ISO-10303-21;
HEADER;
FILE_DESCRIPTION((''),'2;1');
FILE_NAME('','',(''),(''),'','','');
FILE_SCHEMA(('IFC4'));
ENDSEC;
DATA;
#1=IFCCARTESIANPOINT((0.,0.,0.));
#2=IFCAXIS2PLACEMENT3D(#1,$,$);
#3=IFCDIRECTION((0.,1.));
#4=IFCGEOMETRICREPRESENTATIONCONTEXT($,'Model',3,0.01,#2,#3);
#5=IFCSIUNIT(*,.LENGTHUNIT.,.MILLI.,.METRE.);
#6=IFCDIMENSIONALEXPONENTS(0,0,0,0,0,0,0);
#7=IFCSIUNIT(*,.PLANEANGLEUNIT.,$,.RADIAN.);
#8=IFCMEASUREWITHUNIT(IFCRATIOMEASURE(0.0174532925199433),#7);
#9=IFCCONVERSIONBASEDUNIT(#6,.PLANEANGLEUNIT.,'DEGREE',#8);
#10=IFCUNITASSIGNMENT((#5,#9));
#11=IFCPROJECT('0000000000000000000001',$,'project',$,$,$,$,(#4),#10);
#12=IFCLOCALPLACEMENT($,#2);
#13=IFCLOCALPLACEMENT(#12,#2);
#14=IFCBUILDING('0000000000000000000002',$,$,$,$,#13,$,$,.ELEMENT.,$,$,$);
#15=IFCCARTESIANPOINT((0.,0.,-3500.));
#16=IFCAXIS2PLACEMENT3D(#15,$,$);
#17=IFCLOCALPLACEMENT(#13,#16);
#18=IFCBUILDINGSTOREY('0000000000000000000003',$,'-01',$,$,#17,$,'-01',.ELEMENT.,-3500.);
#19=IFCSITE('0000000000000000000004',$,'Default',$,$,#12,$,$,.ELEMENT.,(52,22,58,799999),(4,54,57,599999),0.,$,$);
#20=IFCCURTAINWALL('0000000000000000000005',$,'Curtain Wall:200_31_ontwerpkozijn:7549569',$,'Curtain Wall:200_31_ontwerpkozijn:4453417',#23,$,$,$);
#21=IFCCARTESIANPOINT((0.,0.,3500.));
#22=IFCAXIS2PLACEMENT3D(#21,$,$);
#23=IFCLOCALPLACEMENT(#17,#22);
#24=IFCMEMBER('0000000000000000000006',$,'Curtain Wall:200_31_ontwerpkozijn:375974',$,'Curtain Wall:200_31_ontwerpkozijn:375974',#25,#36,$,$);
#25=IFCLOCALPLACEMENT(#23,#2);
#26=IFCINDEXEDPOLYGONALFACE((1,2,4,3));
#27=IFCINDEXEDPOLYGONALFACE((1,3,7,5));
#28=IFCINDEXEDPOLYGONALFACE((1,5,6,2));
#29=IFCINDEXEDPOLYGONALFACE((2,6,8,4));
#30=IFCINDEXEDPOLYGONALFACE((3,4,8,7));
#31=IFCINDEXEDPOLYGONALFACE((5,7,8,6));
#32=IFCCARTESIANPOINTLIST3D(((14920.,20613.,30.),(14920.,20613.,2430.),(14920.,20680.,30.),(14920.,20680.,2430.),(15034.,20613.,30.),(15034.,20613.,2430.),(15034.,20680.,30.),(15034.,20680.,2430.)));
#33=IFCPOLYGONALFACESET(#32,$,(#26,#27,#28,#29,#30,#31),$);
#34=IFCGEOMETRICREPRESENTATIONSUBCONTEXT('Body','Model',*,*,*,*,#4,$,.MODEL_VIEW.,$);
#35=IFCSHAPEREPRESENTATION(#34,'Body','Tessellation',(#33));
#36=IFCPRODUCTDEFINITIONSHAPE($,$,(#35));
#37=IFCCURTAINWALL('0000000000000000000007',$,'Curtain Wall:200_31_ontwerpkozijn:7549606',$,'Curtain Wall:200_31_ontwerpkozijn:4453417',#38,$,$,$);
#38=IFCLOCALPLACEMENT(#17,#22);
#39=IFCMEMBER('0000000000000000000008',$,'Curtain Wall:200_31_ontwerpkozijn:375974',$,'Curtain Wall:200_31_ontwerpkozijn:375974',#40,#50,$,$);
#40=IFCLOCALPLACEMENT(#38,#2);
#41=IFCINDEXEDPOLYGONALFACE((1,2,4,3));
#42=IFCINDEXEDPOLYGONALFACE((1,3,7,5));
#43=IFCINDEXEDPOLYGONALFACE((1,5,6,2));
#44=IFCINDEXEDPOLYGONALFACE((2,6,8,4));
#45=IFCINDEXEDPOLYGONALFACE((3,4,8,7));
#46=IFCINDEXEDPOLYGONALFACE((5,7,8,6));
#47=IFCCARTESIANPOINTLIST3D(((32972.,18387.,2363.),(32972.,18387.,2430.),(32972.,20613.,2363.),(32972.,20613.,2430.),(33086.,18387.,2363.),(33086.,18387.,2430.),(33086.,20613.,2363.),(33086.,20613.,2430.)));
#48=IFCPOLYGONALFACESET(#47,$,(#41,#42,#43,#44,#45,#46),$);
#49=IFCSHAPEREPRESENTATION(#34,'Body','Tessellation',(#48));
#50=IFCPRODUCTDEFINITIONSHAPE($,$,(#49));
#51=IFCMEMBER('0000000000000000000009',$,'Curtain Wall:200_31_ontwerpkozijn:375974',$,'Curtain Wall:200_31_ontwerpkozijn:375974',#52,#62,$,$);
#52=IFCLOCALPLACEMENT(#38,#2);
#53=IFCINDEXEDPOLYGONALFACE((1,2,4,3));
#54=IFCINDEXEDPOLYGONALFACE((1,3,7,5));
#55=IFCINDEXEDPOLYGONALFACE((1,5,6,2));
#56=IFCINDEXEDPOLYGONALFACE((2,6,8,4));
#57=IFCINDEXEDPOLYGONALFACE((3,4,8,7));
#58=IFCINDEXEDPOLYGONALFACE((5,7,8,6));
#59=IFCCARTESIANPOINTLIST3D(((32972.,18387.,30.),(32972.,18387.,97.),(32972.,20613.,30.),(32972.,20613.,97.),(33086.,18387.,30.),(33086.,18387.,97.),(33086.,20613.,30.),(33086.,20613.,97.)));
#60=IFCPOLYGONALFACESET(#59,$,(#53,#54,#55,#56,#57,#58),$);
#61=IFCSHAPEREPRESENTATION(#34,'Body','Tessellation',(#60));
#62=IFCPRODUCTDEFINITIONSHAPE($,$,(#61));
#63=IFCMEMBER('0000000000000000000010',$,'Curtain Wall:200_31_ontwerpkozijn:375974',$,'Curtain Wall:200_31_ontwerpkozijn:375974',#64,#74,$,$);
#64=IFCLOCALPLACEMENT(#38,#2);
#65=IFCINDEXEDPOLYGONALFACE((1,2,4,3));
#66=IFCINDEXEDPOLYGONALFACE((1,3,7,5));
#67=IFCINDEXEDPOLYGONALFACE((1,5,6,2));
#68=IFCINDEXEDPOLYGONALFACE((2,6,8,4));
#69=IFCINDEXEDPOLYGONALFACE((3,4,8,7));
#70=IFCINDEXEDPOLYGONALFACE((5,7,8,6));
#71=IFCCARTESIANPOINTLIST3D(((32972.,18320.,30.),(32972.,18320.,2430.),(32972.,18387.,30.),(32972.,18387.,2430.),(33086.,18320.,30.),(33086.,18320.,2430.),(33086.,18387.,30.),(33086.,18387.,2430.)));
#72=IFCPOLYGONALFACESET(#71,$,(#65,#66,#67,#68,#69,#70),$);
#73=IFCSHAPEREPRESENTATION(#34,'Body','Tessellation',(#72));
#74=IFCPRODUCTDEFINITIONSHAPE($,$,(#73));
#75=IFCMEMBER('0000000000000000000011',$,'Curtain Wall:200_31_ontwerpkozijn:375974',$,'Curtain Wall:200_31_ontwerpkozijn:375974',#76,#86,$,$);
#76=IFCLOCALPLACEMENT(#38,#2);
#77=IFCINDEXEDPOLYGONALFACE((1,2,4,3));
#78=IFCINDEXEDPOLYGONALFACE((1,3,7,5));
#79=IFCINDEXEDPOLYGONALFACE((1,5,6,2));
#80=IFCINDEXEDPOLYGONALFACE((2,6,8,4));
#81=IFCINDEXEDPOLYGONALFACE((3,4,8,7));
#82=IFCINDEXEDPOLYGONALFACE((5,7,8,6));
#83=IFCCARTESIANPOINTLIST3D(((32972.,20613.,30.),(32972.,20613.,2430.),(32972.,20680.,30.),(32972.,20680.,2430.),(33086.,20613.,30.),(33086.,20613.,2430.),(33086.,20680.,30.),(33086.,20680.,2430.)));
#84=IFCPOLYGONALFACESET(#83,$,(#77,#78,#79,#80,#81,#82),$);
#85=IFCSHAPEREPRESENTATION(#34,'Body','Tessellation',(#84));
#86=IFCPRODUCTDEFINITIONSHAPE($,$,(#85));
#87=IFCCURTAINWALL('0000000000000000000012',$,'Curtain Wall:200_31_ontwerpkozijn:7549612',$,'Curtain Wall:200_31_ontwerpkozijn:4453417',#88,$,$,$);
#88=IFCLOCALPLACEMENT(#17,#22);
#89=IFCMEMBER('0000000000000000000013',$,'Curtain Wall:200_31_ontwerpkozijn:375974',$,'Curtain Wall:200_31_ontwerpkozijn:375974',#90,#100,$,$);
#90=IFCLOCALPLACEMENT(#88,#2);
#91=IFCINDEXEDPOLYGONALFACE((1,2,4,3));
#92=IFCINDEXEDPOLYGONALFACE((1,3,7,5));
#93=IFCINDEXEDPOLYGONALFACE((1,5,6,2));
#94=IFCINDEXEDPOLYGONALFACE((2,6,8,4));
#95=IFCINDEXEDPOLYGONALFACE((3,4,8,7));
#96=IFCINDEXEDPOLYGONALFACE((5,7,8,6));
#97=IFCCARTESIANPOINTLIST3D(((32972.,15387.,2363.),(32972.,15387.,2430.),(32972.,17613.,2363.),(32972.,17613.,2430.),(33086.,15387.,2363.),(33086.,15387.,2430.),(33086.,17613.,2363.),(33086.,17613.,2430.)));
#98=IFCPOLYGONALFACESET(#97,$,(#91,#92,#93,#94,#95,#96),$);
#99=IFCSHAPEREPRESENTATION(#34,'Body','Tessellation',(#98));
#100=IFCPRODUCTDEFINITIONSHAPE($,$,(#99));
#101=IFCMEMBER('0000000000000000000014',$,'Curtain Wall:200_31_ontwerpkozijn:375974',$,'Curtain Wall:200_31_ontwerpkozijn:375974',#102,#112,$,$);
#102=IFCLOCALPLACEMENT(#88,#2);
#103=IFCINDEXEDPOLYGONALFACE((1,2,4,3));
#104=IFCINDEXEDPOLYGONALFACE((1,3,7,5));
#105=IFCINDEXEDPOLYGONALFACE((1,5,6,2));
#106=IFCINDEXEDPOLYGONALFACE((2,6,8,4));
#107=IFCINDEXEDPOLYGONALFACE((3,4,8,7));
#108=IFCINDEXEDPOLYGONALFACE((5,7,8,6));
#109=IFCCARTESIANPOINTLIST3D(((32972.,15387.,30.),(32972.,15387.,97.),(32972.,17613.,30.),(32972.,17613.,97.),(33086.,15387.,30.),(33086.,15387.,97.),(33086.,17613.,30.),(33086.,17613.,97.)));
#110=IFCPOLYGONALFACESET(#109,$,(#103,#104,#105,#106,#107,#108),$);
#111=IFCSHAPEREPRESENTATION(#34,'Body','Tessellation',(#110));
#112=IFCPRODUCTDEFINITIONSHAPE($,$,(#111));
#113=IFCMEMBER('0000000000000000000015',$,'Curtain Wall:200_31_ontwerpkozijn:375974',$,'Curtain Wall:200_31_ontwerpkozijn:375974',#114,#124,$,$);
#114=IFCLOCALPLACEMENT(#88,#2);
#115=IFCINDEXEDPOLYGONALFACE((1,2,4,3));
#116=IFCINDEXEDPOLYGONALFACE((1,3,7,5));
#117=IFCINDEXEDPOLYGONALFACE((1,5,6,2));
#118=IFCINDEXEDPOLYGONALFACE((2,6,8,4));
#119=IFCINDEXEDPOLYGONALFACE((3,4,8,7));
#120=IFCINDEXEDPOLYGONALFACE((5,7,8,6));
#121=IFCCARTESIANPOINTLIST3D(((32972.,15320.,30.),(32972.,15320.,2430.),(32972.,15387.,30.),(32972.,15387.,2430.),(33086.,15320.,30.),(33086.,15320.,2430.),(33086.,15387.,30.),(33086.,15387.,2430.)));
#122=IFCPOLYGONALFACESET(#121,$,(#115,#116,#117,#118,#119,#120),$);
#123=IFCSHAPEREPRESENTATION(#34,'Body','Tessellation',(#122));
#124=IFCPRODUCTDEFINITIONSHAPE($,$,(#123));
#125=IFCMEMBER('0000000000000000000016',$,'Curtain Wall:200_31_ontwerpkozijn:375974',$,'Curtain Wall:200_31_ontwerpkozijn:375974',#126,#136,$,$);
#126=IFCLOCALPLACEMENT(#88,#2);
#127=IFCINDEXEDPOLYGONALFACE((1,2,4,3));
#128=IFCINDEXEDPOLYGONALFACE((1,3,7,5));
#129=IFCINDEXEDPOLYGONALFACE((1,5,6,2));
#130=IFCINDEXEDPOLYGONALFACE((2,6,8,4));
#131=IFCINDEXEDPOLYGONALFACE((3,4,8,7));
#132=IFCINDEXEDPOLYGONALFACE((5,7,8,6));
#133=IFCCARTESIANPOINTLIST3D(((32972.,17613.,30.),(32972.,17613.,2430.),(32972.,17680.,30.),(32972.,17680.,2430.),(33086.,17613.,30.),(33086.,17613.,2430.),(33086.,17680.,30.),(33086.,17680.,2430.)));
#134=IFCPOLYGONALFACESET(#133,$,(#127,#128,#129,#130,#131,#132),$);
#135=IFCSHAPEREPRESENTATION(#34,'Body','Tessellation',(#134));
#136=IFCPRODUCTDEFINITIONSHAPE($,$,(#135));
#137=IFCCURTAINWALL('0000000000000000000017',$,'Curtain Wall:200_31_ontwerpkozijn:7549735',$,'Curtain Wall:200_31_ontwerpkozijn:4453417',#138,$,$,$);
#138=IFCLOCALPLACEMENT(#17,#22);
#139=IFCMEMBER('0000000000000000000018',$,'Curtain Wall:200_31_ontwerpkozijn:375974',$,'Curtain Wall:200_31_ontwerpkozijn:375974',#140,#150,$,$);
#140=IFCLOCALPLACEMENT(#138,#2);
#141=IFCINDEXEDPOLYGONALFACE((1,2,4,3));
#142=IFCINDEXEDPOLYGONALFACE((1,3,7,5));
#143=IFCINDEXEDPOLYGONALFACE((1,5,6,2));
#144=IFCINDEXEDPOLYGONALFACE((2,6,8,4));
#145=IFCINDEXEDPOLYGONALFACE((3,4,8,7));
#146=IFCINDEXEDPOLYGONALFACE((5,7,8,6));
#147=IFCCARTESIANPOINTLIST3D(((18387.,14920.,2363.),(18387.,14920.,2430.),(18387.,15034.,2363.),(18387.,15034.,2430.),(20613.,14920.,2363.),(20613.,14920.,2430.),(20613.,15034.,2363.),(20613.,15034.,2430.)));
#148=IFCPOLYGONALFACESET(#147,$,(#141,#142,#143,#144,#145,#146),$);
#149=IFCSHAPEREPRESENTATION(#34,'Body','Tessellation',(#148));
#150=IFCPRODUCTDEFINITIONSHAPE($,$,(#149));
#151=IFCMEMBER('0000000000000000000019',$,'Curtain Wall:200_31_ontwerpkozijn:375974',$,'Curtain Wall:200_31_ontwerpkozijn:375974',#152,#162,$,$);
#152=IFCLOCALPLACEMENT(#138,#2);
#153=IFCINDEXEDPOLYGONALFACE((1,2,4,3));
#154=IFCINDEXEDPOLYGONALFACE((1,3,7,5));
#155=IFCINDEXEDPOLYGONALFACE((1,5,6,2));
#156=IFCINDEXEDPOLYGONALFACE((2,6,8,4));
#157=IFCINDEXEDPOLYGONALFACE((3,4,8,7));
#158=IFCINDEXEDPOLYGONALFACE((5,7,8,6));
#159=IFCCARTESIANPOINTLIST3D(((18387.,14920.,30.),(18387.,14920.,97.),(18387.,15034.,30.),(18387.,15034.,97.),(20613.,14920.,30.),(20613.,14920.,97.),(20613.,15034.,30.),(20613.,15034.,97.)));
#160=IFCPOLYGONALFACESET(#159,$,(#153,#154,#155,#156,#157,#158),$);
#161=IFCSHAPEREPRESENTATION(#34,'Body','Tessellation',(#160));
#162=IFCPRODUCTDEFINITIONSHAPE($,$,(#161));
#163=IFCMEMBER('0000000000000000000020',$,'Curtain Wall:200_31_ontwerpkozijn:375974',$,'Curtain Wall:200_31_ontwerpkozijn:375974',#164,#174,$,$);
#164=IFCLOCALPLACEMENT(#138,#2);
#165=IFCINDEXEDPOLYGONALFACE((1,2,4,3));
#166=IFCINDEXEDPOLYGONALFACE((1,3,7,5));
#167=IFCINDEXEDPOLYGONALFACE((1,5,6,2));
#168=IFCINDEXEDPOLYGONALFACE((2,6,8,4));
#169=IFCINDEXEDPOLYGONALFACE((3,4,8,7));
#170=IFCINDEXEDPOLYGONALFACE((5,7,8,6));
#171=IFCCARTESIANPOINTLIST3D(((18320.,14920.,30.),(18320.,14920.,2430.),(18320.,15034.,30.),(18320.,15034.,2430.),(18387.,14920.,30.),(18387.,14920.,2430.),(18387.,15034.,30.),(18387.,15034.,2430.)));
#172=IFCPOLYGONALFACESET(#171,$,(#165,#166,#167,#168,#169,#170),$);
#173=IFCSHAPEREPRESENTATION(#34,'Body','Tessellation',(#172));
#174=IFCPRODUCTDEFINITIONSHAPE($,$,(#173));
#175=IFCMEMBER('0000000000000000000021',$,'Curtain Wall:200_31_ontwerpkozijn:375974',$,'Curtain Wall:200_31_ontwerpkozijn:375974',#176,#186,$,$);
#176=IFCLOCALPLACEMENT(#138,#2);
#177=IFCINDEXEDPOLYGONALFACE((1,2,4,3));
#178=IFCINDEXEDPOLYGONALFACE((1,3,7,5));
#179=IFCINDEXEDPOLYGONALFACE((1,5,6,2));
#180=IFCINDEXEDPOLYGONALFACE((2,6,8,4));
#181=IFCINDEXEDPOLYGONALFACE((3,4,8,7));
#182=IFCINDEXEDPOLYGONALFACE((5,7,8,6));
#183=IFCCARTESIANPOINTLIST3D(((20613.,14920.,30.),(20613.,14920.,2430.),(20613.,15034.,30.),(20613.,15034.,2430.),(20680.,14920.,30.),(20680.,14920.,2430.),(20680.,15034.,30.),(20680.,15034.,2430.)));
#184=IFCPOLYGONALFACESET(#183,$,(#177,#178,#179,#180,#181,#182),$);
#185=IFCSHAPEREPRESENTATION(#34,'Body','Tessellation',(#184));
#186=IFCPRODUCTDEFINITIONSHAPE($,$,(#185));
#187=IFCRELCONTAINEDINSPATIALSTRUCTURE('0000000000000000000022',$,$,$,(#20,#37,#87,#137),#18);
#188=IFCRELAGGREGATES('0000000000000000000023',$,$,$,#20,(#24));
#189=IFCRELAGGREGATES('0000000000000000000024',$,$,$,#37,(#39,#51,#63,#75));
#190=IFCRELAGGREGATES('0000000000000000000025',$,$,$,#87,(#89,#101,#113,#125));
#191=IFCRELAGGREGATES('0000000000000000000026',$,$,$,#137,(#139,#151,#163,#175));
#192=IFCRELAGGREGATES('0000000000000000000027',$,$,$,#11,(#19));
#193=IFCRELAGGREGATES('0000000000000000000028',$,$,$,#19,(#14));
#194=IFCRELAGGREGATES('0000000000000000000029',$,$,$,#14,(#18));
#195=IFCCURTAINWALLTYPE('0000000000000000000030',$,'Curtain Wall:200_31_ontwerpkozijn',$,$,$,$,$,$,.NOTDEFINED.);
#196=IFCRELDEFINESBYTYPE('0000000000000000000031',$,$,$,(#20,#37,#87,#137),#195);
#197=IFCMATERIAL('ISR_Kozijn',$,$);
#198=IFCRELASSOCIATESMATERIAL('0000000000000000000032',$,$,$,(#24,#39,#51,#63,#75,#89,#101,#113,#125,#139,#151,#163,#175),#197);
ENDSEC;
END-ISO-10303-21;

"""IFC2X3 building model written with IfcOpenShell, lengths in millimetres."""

from ifc_helpers import new_model, entity, si_unit, converted_unit, direction, frame, frame_2d, origin, origin_2d_with_axis, place, context, subcontext, project, spatial, rectangle, extrude, material, type_object, element, aggregate, save


model = new_model("IFC2X3")

# Units and contexts
model_context = context("Model", 3, precision=0.01, world=origin(), true_north=direction((0.0, 1.0)))
body_context = subcontext(model_context, "Body", "Model", "MODEL_VIEW")
ifc_project = project(units=[si_unit("LENGTHUNIT", "METRE", prefix="MILLI"), converted_unit("PLANEANGLEUNIT", "DEGREE", entity("IfcRatioMeasure", 0.0174532925199433), si_unit("PLANEANGLEUNIT", "RADIAN"), dimensions=[0, 0, 0, 0, 0, 0, 0])], contexts=[model_context])

# Site, building, storey
site_placement = place(None, origin())
site = spatial("IfcSite", under=ifc_project, at=site_placement, Name="Default", CompositionType="ELEMENT", RefLatitude=(52, 22, 58, 799999), RefLongitude=(4, 54, 57, 599999), RefElevation=0.0)
building_placement = place(site_placement, origin())
building = spatial("IfcBuilding", under=site, at=building_placement, CompositionType="ELEMENT")
storey_placement = place(building_placement, frame((0.0, 0.0, -3500.0)))
storey = spatial("IfcBuildingStorey", under=building, at=storey_placement, Name="-01", LongName="-01", CompositionType="ELEMENT", Elevation=-3500.0)

# Curtain wall, member
curtain_wall_type = type_object("IfcCurtainWallType", Name="Curtain Wall:200_31_ontwerpkozijn", PredefinedType="NOTDEFINED")
curtain_wall_1_placement = place(storey_placement, frame((0.0, 0.0, 3500.0)))
curtain_wall_1 = element("IfcCurtainWall", 1, at=curtain_wall_1_placement, inside=storey, type_object=curtain_wall_type, Name="Curtain Wall:200_31_ontwerpkozijn:7549569", ObjectType="Curtain Wall:200_31_ontwerpkozijn:4453417")
ifc_material = material(Name="ISR_Kozijn")
member_1_placement = place(curtain_wall_1_placement, origin())
member_1 = element("IfcMember", 2, at=member_1_placement, material=ifc_material, Name="Curtain Wall:200_31_ontwerpkozijn:375974", ObjectType="Curtain Wall:200_31_ontwerpkozijn:375974", context=body_context, shape_type="SweptSolid", body=[
    extrude(rectangle(XDim=114.0, YDim=67.0, at=origin_2d_with_axis()), frame((14977.0, 20646.5, 2430.0), z_axis=(0.0, 0.0, -1.0), x_axis=(-1.0, 0.0, 0.0)), (0.0, 0.0, 1.0), 2400.0),
])
aggregate(curtain_wall_1, [member_1])

# Curtain walls, members
curtain_wall_2_placement = place(storey_placement, frame((0.0, 0.0, 3500.0)))
curtain_wall_2 = element("IfcCurtainWall", 3, at=curtain_wall_2_placement, inside=storey, type_object=curtain_wall_type, Name="Curtain Wall:200_31_ontwerpkozijn:7549606", ObjectType="Curtain Wall:200_31_ontwerpkozijn:4453417")
member_2_placement = place(curtain_wall_2_placement, origin())
member_2 = element("IfcMember", 4, at=member_2_placement, material=ifc_material, Name="Curtain Wall:200_31_ontwerpkozijn:375974", ObjectType="Curtain Wall:200_31_ontwerpkozijn:375974", context=body_context, shape_type="SweptSolid", body=[
    extrude(rectangle(XDim=67.0, YDim=114.0, at=origin_2d_with_axis()), frame((33029.0, 18387.0, 2396.5), z_axis=(0.0, 1.0, 0.0), x_axis=(0.0, 0.0, -1.0)), (0.0, 0.0, 1.0), 2226.0),
])
member_3_placement = place(curtain_wall_2_placement, origin())
member_3 = element("IfcMember", 5, at=member_3_placement, material=ifc_material, Name="Curtain Wall:200_31_ontwerpkozijn:375974", ObjectType="Curtain Wall:200_31_ontwerpkozijn:375974", context=body_context, shape_type="SweptSolid", body=[
    extrude(rectangle(XDim=67.0, YDim=114.0, at=origin_2d_with_axis()), frame((33029.0, 20613.0, 63.5), z_axis=(0.0, -1.0, 0.0), x_axis=(0.0, 0.0, -1.0)), (0.0, 0.0, 1.0), 2226.0),
])
member_4_placement = place(curtain_wall_2_placement, origin())
member_4 = element("IfcMember", 6, at=member_4_placement, material=ifc_material, Name="Curtain Wall:200_31_ontwerpkozijn:375974", ObjectType="Curtain Wall:200_31_ontwerpkozijn:375974", context=body_context, shape_type="SweptSolid", body=[
    extrude(rectangle(XDim=114.0, YDim=67.0, at=frame_2d((0.0, 0.0), x_axis=(1.0, 0.0))), frame((33029.0, 18353.5, 30.0), z_axis=(0.0, 0.0, 1.0), x_axis=(-1.0, 0.0, 0.0)), (0.0, 0.0, 1.0), 2400.0),
])
member_5_placement = place(curtain_wall_2_placement, origin())
member_5 = element("IfcMember", 7, at=member_5_placement, material=ifc_material, Name="Curtain Wall:200_31_ontwerpkozijn:375974", ObjectType="Curtain Wall:200_31_ontwerpkozijn:375974", context=body_context, shape_type="SweptSolid", body=[
    extrude(rectangle(XDim=114.0, YDim=67.0, at=origin_2d_with_axis()), frame((33029.0, 20646.5, 2430.0), z_axis=(0.0, 0.0, -1.0), x_axis=(-1.0, 0.0, 0.0)), (0.0, 0.0, 1.0), 2400.0),
])
aggregate(curtain_wall_2, [member_2, member_3, member_4, member_5])
curtain_wall_3_placement = place(storey_placement, frame((0.0, 0.0, 3500.0)))
curtain_wall_3 = element("IfcCurtainWall", 8, at=curtain_wall_3_placement, inside=storey, type_object=curtain_wall_type, Name="Curtain Wall:200_31_ontwerpkozijn:7549612", ObjectType="Curtain Wall:200_31_ontwerpkozijn:4453417")
member_6_placement = place(curtain_wall_3_placement, origin())
member_6 = element("IfcMember", 9, at=member_6_placement, material=ifc_material, Name="Curtain Wall:200_31_ontwerpkozijn:375974", ObjectType="Curtain Wall:200_31_ontwerpkozijn:375974", context=body_context, shape_type="SweptSolid", body=[
    extrude(rectangle(XDim=67.0, YDim=114.0, at=origin_2d_with_axis()), frame((33029.0, 15387.0, 2396.5), z_axis=(0.0, 1.0, 0.0), x_axis=(0.0, 0.0, -1.0)), (0.0, 0.0, 1.0), 2226.0),
])
member_7_placement = place(curtain_wall_3_placement, origin())
member_7 = element("IfcMember", 10, at=member_7_placement, material=ifc_material, Name="Curtain Wall:200_31_ontwerpkozijn:375974", ObjectType="Curtain Wall:200_31_ontwerpkozijn:375974", context=body_context, shape_type="SweptSolid", body=[
    extrude(rectangle(XDim=67.0, YDim=114.0, at=origin_2d_with_axis()), frame((33029.0, 17613.0, 63.5), z_axis=(0.0, -1.0, 0.0), x_axis=(0.0, 0.0, -1.0)), (0.0, 0.0, 1.0), 2226.0),
])
member_8_placement = place(curtain_wall_3_placement, origin())
member_8 = element("IfcMember", 11, at=member_8_placement, material=ifc_material, Name="Curtain Wall:200_31_ontwerpkozijn:375974", ObjectType="Curtain Wall:200_31_ontwerpkozijn:375974", context=body_context, shape_type="SweptSolid", body=[
    extrude(rectangle(XDim=114.0, YDim=67.0, at=frame_2d((0.0, 0.0), x_axis=(1.0, 0.0))), frame((33029.0, 15353.5, 30.0), z_axis=(0.0, 0.0, 1.0), x_axis=(-1.0, 0.0, 0.0)), (0.0, 0.0, 1.0), 2400.0),
])
member_9_placement = place(curtain_wall_3_placement, origin())
member_9 = element("IfcMember", 12, at=member_9_placement, material=ifc_material, Name="Curtain Wall:200_31_ontwerpkozijn:375974", ObjectType="Curtain Wall:200_31_ontwerpkozijn:375974", context=body_context, shape_type="SweptSolid", body=[
    extrude(rectangle(XDim=114.0, YDim=67.0, at=frame_2d((0.0, 0.0), x_axis=(1.0, 0.0))), frame((33029.0, 17646.5, 2430.0), z_axis=(0.0, 0.0, -1.0), x_axis=(-1.0, 0.0, 0.0)), (0.0, 0.0, 1.0), 2400.0),
])
aggregate(curtain_wall_3, [member_6, member_7, member_8, member_9])
curtain_wall_4_placement = place(storey_placement, frame((0.0, 0.0, 3500.0)))
curtain_wall_4 = element("IfcCurtainWall", 13, at=curtain_wall_4_placement, inside=storey, type_object=curtain_wall_type, Name="Curtain Wall:200_31_ontwerpkozijn:7549735", ObjectType="Curtain Wall:200_31_ontwerpkozijn:4453417")
member_10_placement = place(curtain_wall_4_placement, origin())
member_10 = element("IfcMember", 14, at=member_10_placement, material=ifc_material, Name="Curtain Wall:200_31_ontwerpkozijn:375974", ObjectType="Curtain Wall:200_31_ontwerpkozijn:375974", context=body_context, shape_type="SweptSolid", body=[
    extrude(rectangle(XDim=67.0, YDim=114.0, at=frame_2d((0.0, 0.0), x_axis=(1.0, 0.0))), frame((18387.0, 14977.0, 2396.5), z_axis=(1.0, 0.0, 0.0), x_axis=(0.0, 0.0, -1.0)), (0.0, 0.0, 1.0), 2226.0),
])
member_11_placement = place(curtain_wall_4_placement, origin())
member_11 = element("IfcMember", 15, at=member_11_placement, material=ifc_material, Name="Curtain Wall:200_31_ontwerpkozijn:375974", ObjectType="Curtain Wall:200_31_ontwerpkozijn:375974", context=body_context, shape_type="SweptSolid", body=[
    extrude(rectangle(XDim=67.0, YDim=114.0, at=frame_2d((0.0, 0.0), x_axis=(1.0, 0.0))), frame((20613.0, 14977.0, 63.5), z_axis=(-1.0, 0.0, 0.0), x_axis=(0.0, 0.0, -1.0)), (0.0, 0.0, 1.0), 2226.0),
])
member_12_placement = place(curtain_wall_4_placement, origin())
member_12 = element("IfcMember", 16, at=member_12_placement, material=ifc_material, Name="Curtain Wall:200_31_ontwerpkozijn:375974", ObjectType="Curtain Wall:200_31_ontwerpkozijn:375974", context=body_context, shape_type="SweptSolid", body=[
    extrude(rectangle(XDim=67.0, YDim=114.0, at=frame_2d((0.0, 0.0), x_axis=(1.0, 0.0))), frame((18353.5, 14977.0, 30.0), z_axis=(0.0, 0.0, 1.0), x_axis=(-1.0, 0.0, 0.0)), (0.0, 0.0, 1.0), 2400.0),
])
member_13_placement = place(curtain_wall_4_placement, origin())
member_13 = element("IfcMember", 17, at=member_13_placement, material=ifc_material, Name="Curtain Wall:200_31_ontwerpkozijn:375974", ObjectType="Curtain Wall:200_31_ontwerpkozijn:375974", context=body_context, shape_type="SweptSolid", body=[
    extrude(rectangle(XDim=67.0, YDim=114.0, at=origin_2d_with_axis()), frame((20646.5, 14977.0, 2430.0), z_axis=(0.0, 0.0, -1.0), x_axis=(-1.0, 0.0, 0.0)), (0.0, 0.0, 1.0), 2400.0),
])
aggregate(curtain_wall_4, [member_10, member_11, member_12, member_13])

save(model, "model.ifc")
